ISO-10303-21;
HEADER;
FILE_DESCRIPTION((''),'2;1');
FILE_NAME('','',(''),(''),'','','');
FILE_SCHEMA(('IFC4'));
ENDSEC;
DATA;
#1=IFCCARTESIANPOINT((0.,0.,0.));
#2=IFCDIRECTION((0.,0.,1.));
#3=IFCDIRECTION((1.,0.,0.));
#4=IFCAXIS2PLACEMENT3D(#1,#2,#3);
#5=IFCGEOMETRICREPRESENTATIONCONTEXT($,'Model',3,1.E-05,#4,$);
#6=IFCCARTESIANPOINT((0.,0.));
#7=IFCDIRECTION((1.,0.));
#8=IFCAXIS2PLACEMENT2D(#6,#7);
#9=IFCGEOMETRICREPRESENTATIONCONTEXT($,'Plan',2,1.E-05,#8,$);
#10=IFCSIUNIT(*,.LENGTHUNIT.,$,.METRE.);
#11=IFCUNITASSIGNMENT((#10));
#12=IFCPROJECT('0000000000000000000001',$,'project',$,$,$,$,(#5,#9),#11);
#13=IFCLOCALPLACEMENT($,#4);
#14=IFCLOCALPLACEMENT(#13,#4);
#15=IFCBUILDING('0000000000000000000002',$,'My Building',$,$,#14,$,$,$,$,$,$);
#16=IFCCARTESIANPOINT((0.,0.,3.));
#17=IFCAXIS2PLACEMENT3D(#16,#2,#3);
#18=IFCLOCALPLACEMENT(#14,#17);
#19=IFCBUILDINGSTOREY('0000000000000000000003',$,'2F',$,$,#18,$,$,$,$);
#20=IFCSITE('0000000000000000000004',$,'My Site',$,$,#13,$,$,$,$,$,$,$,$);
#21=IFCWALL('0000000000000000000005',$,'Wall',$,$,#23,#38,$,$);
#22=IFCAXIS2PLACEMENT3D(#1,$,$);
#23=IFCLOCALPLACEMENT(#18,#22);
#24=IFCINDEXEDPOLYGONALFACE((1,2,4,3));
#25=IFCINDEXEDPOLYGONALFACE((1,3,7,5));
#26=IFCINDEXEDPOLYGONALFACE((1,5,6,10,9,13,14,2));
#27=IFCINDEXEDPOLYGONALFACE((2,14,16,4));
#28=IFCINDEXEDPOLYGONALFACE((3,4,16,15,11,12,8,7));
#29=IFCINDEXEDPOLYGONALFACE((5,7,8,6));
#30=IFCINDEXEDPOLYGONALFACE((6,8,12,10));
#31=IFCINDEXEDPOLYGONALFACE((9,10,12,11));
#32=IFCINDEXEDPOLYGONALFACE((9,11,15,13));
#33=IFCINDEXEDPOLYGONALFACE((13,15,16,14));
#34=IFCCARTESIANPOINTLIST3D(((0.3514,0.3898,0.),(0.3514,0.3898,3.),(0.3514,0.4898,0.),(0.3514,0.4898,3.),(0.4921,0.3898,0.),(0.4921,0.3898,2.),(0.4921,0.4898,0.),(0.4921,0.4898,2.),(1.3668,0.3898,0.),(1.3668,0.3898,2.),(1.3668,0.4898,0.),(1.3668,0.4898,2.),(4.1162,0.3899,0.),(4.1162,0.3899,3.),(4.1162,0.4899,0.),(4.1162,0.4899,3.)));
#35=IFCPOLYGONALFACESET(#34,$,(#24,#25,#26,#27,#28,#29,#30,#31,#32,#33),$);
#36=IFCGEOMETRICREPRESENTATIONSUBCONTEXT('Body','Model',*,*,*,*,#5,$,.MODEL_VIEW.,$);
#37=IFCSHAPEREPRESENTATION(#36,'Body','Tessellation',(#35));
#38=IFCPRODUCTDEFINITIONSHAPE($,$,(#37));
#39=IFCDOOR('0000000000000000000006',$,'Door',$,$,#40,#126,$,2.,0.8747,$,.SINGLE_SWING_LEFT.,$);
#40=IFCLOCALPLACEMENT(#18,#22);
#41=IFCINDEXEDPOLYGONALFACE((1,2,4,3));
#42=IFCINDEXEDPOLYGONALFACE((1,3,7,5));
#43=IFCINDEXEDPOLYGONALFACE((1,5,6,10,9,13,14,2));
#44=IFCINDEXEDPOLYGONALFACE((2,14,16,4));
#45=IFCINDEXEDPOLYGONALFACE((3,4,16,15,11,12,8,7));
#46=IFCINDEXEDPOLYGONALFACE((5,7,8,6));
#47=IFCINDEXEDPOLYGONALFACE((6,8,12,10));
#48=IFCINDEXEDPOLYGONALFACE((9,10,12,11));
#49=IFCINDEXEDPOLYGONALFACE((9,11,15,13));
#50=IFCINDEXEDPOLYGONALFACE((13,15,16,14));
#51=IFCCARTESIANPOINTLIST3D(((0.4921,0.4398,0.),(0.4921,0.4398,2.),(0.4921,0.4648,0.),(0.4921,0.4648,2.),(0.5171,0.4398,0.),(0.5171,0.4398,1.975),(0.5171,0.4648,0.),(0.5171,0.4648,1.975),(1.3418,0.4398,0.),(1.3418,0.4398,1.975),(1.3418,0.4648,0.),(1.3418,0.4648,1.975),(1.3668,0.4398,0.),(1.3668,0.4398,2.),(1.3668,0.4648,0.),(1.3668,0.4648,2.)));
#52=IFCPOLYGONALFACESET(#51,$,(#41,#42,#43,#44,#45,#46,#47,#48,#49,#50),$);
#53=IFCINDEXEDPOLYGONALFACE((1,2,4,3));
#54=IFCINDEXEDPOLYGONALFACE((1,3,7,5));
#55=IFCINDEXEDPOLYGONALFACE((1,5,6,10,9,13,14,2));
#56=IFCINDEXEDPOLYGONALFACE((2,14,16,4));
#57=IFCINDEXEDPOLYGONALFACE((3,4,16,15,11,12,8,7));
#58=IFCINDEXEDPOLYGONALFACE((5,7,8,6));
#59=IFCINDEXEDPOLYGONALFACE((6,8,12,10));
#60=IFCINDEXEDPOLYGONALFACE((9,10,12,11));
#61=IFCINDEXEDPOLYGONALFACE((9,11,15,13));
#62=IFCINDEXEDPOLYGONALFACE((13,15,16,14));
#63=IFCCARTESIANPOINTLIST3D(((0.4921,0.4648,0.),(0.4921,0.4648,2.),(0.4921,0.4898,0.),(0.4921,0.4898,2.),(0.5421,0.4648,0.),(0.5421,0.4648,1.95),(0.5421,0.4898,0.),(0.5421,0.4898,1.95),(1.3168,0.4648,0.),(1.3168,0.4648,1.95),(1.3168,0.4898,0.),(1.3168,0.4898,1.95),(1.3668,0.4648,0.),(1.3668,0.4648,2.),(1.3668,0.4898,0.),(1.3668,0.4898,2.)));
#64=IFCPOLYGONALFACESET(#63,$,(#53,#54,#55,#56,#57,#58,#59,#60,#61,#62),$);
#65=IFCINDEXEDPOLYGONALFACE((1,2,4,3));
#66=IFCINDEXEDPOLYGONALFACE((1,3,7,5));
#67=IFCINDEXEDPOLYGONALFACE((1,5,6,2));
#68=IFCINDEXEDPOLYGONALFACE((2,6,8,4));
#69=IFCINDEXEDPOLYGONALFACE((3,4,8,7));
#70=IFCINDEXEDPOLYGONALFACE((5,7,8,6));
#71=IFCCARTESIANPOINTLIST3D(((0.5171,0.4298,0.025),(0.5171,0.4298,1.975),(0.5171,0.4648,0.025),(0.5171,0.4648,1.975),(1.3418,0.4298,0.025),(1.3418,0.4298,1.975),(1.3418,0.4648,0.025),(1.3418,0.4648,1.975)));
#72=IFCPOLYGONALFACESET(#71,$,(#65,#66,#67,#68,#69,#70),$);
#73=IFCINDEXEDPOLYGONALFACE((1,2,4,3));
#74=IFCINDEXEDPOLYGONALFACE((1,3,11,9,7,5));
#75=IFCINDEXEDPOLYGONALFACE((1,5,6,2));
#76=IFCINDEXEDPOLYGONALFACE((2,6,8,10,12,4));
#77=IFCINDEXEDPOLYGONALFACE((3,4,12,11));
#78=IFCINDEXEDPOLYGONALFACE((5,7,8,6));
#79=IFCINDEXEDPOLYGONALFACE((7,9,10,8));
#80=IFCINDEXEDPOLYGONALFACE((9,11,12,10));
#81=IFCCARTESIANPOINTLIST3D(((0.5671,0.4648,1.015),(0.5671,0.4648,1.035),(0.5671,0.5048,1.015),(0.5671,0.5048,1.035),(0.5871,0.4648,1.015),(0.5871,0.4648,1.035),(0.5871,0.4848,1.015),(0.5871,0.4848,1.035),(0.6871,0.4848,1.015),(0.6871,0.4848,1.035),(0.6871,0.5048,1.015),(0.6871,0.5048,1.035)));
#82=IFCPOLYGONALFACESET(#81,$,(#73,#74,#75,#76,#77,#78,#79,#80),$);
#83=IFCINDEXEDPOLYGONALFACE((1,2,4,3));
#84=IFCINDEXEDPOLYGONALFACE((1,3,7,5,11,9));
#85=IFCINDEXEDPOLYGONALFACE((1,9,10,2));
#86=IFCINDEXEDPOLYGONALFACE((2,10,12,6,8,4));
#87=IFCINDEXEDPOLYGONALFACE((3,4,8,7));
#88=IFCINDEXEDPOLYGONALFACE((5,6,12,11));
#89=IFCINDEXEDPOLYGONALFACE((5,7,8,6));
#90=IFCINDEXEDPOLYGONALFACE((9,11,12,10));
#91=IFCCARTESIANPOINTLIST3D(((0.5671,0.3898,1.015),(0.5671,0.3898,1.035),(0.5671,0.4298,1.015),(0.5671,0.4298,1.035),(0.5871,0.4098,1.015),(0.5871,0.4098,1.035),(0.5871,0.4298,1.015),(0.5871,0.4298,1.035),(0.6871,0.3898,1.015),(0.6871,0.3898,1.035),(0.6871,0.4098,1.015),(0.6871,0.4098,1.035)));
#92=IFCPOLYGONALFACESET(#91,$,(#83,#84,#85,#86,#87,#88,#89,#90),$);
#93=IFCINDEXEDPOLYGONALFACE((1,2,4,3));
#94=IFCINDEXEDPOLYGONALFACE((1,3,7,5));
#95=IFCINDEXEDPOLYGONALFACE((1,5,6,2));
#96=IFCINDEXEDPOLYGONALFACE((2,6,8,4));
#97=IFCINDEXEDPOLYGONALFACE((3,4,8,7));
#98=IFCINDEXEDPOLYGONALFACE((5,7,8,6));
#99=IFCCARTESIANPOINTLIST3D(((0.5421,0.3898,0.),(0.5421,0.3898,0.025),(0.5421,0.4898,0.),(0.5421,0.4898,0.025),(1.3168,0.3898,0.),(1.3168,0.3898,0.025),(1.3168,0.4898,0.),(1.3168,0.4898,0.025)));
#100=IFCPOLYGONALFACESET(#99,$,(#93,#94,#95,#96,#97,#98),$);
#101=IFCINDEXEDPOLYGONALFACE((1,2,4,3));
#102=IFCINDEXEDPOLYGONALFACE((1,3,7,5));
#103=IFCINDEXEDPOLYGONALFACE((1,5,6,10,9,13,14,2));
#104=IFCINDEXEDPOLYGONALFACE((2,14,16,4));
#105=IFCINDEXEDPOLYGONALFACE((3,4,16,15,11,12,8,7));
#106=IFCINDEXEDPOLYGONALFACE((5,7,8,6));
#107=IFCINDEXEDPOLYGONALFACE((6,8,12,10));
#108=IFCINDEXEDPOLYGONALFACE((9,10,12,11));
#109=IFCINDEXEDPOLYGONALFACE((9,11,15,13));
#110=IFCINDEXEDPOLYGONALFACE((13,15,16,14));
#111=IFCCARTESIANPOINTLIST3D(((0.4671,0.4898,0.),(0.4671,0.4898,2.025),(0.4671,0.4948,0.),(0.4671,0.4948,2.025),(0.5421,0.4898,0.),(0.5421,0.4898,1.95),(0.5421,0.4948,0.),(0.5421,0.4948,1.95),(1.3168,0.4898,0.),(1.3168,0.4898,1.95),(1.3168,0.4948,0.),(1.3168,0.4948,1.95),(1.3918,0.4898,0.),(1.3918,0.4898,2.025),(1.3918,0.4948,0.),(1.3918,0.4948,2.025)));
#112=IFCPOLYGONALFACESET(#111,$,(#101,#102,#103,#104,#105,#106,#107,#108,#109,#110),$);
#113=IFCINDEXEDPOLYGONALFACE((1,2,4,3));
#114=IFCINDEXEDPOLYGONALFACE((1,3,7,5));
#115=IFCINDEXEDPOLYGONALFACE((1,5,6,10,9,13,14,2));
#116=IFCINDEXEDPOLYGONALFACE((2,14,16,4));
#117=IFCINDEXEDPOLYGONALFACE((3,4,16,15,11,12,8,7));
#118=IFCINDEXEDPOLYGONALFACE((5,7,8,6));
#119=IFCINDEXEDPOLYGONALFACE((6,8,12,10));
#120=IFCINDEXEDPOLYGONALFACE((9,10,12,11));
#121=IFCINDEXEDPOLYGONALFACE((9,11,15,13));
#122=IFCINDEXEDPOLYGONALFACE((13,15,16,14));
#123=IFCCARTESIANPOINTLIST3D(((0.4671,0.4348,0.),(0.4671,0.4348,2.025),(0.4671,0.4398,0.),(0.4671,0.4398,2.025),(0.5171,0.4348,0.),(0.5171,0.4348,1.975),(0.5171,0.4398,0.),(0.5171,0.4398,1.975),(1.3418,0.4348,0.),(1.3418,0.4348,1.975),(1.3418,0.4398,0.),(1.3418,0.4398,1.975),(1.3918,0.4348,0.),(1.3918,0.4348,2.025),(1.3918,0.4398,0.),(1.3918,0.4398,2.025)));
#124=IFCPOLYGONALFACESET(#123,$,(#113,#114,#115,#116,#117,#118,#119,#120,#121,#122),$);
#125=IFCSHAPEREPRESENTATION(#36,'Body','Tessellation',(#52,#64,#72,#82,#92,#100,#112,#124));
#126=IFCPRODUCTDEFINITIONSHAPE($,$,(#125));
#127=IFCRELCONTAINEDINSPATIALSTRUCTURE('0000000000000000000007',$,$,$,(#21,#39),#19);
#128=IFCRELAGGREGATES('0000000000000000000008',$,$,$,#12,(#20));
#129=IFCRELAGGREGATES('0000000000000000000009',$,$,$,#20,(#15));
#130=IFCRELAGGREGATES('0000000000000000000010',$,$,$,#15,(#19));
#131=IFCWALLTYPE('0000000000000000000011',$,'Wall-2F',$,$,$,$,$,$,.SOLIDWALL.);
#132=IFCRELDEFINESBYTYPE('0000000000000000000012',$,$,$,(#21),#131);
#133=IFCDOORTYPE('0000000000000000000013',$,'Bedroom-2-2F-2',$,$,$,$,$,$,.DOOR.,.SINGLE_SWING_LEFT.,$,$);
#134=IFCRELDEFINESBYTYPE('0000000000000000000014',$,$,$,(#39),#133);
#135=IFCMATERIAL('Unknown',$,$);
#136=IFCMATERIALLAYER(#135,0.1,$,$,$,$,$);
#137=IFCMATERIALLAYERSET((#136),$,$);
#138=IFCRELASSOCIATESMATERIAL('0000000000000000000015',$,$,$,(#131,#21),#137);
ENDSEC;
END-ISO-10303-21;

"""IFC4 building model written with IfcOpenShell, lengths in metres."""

from ifc_helpers import new_model, entity, si_unit, frame, origin_with_axes, origin_2d_with_axis, place, context, subcontext, project, spatial, line, indexed_curve, outline, extrude, shape, source, transform, mapped, material, layer, layer_set, layer_usage, type_object, type_shapes, element, fill, save


model = new_model("IFC4")

# Units and contexts
model_context = context("Model", 3, precision=1e-05, world=origin_with_axes())
plan_context = context("Plan", 2, precision=1e-05, world=origin_2d_with_axis())
body_context_1 = subcontext(model_context, "Body", "Model", "MODEL_VIEW")
body_context_2 = subcontext(plan_context, "Body", "Plan", "PLAN_VIEW")
ifc_project = project(units=[si_unit("LENGTHUNIT", "METRE")], contexts=[model_context, plan_context])

# Site, building, storey
site_placement = place(None, origin_with_axes())
site = spatial("IfcSite", under=ifc_project, at=site_placement, Name="My Site")
building_placement = place(site_placement, origin_with_axes())
building = spatial("IfcBuilding", under=site, at=building_placement, Name="My Building")
storey_placement = place(building_placement, frame((0.0, 0.0, 3.0), z_axis=(0.0, 0.0, 1.0), x_axis=(1.0, 0.0, 0.0)))
storey = spatial("IfcBuildingStorey", under=building, at=storey_placement, Name="2F")

# Shared definitions
ifc_material = material(Name="Unknown")

# Shared definitions
ifc_layer_1 = layer(ifc_material, 0.1)
ifc_layer_set_1 = layer_set([ifc_layer_1])
wall_type = type_object("IfcWallType", Name="Wall-2F", PredefinedType="SOLIDWALL", material=ifc_layer_set_1)

# Wall, opening, door
ifc_layer_usage_1 = layer_usage(ifc_layer_set_1, "AXIS2", "POSITIVE", 0.0)
wall_1_placement = place(storey_placement, frame((0.3514, 0.3898, 0.0), z_axis=(0.0, 0.0, 1.0), x_axis=(1.0, 0.000024, 0.0)))
wall_1 = element("IfcWall", 1, at=wall_1_placement, inside=storey, type_object=wall_type, material=ifc_layer_usage_1, Name="Wall", context=body_context_1, shape_type="SweptSolid", body=[
    extrude(outline(indexed_curve([(0.0, 0.0), (0.0, 0.1), (3.7648, 0.1), (3.7648, 0.0)], segments=[line(1, 2, 3, 4, 1)])), origin_with_axes(), (0.0, 0.0, 1.0), 3.0),
])
shared_shape_1 = source(origin_with_axes(), body_context_1, "Body", "SweptSolid", [
    extrude(outline(indexed_curve([(0.0, 0.0), (0.8747, 0.0), (0.8747, 2.0), (0.0, 2.0)], segments=[line(1, 2, 3, 4, 1)])), frame((0.0, -0.6, 0.0), z_axis=(0.0, -1.0, 0.0), x_axis=(1.0, 0.0, 0.0)), (0.0, 0.0, -1.0), 1.2),
])
opening_1_placement = place(wall_1_placement, frame((0.1407, 0.015, 0.0), z_axis=(0.0, 0.0, 1.0), x_axis=(1.0, -0.000001, 0.0)))
opening_1 = element("IfcOpeningElement", 2, at=opening_1_placement, cuts=wall_1, PredefinedType="OPENING", context=body_context_1, shape_type="MappedRepresentation", body=[
    mapped(shared_shape_1, transform((0.0, 0.0, 0.0), x_axis=(1.0, 0.0, 0.0), y_axis=(0.0, 1.0, 0.0), z_axis=(0.0, 0.0, 1.0), scale=1.0)),
])
door_type_1 = type_object("IfcDoorType", Name="Bedroom-2-2F-2", OperationType="SINGLE_SWING_LEFT", PredefinedType="DOOR")
shared_shape_2 = source(origin_with_axes(), body_context_1, "Body", "SweptSolid", [
    extrude(outline(indexed_curve([(0.0, 0.0), (0.0, 2.0), (0.8747, 2.0), (0.8747, 0.0), (0.8497, 0.0), (0.8497, 1.975), (0.025, 1.975), (0.025, 0.0)], segments=[line(1, 2, 3, 4, 5, 6, 7, 8, 1)])), frame((0.0, 0.025, 0.0), z_axis=(0.0, -1.0, 0.0), x_axis=(1.0, 0.0, 0.0)), (0.0, 0.0, -1.0), 0.025),
    extrude(outline(indexed_curve([(0.0, 0.0), (0.0, 2.0), (0.8747, 2.0), (0.8747, 0.0), (0.8247, 0.0), (0.8247, 1.95), (0.05, 1.95), (0.05, 0.0)], segments=[line(1, 2, 3, 4, 5, 6, 7, 8, 1)])), frame((0.0, 0.0, 0.0), z_axis=(0.0, -1.0, 0.0), x_axis=(1.0, 0.0, 0.0)), (0.0, 0.0, -1.0), 0.025),
    extrude(outline(indexed_curve([(0.0, 0.0), (0.8247, 0.0), (0.8247, 0.035), (0.0, 0.035)], segments=[line(1, 2, 3, 4, 1)])), frame((0.025, 0.025, 0.025), z_axis=(0.0, 0.0, 1.0), x_axis=(1.0, 0.0, 0.0)), (0.0, 0.0, 1.0), 1.95),
    extrude(outline(indexed_curve([(0.0, 0.0), (0.0, -0.04), (-0.12, -0.04), (-0.12, -0.02), (-0.02, -0.02), (-0.02, 0.0)], segments=[line(1, 2, 3, 4, 5, 6, 1)])), frame((0.7997, 0.025, 1.015), z_axis=(0.0, 0.0, 1.0), x_axis=(1.0, 0.0, 0.0)), (0.0, 0.0, 1.0), 0.02),
    extrude(outline(indexed_curve([(0.0, 0.0), (0.0, 0.04), (-0.12, 0.04), (-0.12, 0.02), (-0.02, 0.02), (-0.02, 0.0)], segments=[line(1, 2, 3, 4, 5, 6, 1)])), frame((0.7997, 0.06, 1.015), z_axis=(0.0, 0.0, 1.0), x_axis=(1.0, 0.0, 0.0)), (0.0, 0.0, 1.0), 0.02),
    extrude(outline(indexed_curve([(0.0, 0.0), (0.7747, 0.0), (0.7747, 0.1), (0.0, 0.1)], segments=[line(1, 2, 3, 4, 1)])), frame((0.05, 0.0, 0.0), z_axis=(0.0, 0.0, 1.0), x_axis=(1.0, 0.0, 0.0)), (0.0, 0.0, 1.0), 0.025),
    extrude(outline(indexed_curve([(0.0, 0.0), (0.0, 2.025), (0.9247, 2.025), (0.9247, 0.0), (0.8497, 0.0), (0.8497, 1.95), (0.075, 1.95), (0.075, 0.0)], segments=[line(1, 2, 3, 4, 5, 6, 7, 8, 1)])), frame((-0.025, -0.005, 0.0), z_axis=(0.0, -1.0, 0.0), x_axis=(1.0, 0.0, 0.0)), (0.0, 0.0, -1.0), 0.005),
    extrude(outline(indexed_curve([(0.0, 0.0), (0.0, 2.025), (0.9247, 2.025), (0.9247, 0.0), (0.8747, 0.0), (0.8747, 1.975), (0.05, 1.975), (0.05, 0.0)], segments=[line(1, 2, 3, 4, 5, 6, 7, 8, 1)])), frame((-0.025, 0.05, 0.0), z_axis=(0.0, -1.0, 0.0), x_axis=(1.0, 0.0, 0.0)), (0.0, 0.0, -1.0), 0.005),
])
shared_shape_3 = source(origin_with_axes(), body_context_2, "Body", "Curve2D", [
    entity("IfcIndexedPolyCurve", entity("IfcCartesianPointList2D", [[0.0, 0.0], [0.0, 0.05], [0.025, 0.05], [0.025, 0.025], [0.05, 0.025], [0.05, 0.0]]), [entity("IfcLineIndex", [1, 2, 3, 4, 5, 6, 1])]),
    entity("IfcIndexedPolyCurve", entity("IfcCartesianPointList2D", [[0.8747, 0.0], [0.8747, 0.05], [0.8497, 0.05], [0.8497, 0.025], [0.8247, 0.025], [0.8247, 0.0]]), [entity("IfcLineIndex", [1, 2, 3, 4, 5, 6, 1])]),
    entity("IfcTrimmedCurve", entity("IfcEllipse", entity("IfcAxis2Placement2D", entity("IfcCartesianPoint", [0.06, 0.05]), entity("IfcDirection", [1.0, 0.0])), 0.7897, 0.8247), [entity("IfcCartesianPoint", [0.8497, 0.05])], [entity("IfcCartesianPoint", [0.06, 0.8747])], True, "CARTESIAN"),
    entity("IfcIndexedPolyCurve", entity("IfcCartesianPointList2D", [[0.025, 0.05], [0.06, 0.05], [0.06, 0.8747], [0.025, 0.8747]]), [entity("IfcLineIndex", [1, 2, 3, 4, 1])]),
])
type_shapes(door_type_1, [shared_shape_2, shared_shape_3])
door_1_placement = place(opening_1_placement, frame((0.8747, 0.085, 0.0), z_axis=(0.0, 0.0, 1.0), x_axis=(-1.0, 0.0, 0.0)))
door_1 = element("IfcDoor", 3, at=door_1_placement, inside=storey, type_object=door_type_1, Name="Door", OperationType="SINGLE_SWING_LEFT", OverallHeight=2.0, OverallWidth=0.8747, shapes=[
    shape(body_context_1, "Body", "MappedRepresentation", [mapped(shared_shape_2, transform((0.0, 0.0, 0.0), x_axis=(1.0, 0.0, 0.0), y_axis=(0.0, 1.0, 0.0), z_axis=(0.0, 0.0, 1.0), scale=1.0))]),
    shape(body_context_2, "Body", "MappedRepresentation", [mapped(shared_shape_3, transform((0.0, 0.0, 0.0), x_axis=(1.0, 0.0, 0.0), y_axis=(0.0, 1.0, 0.0), z_axis=(0.0, 0.0, 1.0), scale=1.0))]),
])
fill(opening_1, door_1)

save(model, "model.ifc")
